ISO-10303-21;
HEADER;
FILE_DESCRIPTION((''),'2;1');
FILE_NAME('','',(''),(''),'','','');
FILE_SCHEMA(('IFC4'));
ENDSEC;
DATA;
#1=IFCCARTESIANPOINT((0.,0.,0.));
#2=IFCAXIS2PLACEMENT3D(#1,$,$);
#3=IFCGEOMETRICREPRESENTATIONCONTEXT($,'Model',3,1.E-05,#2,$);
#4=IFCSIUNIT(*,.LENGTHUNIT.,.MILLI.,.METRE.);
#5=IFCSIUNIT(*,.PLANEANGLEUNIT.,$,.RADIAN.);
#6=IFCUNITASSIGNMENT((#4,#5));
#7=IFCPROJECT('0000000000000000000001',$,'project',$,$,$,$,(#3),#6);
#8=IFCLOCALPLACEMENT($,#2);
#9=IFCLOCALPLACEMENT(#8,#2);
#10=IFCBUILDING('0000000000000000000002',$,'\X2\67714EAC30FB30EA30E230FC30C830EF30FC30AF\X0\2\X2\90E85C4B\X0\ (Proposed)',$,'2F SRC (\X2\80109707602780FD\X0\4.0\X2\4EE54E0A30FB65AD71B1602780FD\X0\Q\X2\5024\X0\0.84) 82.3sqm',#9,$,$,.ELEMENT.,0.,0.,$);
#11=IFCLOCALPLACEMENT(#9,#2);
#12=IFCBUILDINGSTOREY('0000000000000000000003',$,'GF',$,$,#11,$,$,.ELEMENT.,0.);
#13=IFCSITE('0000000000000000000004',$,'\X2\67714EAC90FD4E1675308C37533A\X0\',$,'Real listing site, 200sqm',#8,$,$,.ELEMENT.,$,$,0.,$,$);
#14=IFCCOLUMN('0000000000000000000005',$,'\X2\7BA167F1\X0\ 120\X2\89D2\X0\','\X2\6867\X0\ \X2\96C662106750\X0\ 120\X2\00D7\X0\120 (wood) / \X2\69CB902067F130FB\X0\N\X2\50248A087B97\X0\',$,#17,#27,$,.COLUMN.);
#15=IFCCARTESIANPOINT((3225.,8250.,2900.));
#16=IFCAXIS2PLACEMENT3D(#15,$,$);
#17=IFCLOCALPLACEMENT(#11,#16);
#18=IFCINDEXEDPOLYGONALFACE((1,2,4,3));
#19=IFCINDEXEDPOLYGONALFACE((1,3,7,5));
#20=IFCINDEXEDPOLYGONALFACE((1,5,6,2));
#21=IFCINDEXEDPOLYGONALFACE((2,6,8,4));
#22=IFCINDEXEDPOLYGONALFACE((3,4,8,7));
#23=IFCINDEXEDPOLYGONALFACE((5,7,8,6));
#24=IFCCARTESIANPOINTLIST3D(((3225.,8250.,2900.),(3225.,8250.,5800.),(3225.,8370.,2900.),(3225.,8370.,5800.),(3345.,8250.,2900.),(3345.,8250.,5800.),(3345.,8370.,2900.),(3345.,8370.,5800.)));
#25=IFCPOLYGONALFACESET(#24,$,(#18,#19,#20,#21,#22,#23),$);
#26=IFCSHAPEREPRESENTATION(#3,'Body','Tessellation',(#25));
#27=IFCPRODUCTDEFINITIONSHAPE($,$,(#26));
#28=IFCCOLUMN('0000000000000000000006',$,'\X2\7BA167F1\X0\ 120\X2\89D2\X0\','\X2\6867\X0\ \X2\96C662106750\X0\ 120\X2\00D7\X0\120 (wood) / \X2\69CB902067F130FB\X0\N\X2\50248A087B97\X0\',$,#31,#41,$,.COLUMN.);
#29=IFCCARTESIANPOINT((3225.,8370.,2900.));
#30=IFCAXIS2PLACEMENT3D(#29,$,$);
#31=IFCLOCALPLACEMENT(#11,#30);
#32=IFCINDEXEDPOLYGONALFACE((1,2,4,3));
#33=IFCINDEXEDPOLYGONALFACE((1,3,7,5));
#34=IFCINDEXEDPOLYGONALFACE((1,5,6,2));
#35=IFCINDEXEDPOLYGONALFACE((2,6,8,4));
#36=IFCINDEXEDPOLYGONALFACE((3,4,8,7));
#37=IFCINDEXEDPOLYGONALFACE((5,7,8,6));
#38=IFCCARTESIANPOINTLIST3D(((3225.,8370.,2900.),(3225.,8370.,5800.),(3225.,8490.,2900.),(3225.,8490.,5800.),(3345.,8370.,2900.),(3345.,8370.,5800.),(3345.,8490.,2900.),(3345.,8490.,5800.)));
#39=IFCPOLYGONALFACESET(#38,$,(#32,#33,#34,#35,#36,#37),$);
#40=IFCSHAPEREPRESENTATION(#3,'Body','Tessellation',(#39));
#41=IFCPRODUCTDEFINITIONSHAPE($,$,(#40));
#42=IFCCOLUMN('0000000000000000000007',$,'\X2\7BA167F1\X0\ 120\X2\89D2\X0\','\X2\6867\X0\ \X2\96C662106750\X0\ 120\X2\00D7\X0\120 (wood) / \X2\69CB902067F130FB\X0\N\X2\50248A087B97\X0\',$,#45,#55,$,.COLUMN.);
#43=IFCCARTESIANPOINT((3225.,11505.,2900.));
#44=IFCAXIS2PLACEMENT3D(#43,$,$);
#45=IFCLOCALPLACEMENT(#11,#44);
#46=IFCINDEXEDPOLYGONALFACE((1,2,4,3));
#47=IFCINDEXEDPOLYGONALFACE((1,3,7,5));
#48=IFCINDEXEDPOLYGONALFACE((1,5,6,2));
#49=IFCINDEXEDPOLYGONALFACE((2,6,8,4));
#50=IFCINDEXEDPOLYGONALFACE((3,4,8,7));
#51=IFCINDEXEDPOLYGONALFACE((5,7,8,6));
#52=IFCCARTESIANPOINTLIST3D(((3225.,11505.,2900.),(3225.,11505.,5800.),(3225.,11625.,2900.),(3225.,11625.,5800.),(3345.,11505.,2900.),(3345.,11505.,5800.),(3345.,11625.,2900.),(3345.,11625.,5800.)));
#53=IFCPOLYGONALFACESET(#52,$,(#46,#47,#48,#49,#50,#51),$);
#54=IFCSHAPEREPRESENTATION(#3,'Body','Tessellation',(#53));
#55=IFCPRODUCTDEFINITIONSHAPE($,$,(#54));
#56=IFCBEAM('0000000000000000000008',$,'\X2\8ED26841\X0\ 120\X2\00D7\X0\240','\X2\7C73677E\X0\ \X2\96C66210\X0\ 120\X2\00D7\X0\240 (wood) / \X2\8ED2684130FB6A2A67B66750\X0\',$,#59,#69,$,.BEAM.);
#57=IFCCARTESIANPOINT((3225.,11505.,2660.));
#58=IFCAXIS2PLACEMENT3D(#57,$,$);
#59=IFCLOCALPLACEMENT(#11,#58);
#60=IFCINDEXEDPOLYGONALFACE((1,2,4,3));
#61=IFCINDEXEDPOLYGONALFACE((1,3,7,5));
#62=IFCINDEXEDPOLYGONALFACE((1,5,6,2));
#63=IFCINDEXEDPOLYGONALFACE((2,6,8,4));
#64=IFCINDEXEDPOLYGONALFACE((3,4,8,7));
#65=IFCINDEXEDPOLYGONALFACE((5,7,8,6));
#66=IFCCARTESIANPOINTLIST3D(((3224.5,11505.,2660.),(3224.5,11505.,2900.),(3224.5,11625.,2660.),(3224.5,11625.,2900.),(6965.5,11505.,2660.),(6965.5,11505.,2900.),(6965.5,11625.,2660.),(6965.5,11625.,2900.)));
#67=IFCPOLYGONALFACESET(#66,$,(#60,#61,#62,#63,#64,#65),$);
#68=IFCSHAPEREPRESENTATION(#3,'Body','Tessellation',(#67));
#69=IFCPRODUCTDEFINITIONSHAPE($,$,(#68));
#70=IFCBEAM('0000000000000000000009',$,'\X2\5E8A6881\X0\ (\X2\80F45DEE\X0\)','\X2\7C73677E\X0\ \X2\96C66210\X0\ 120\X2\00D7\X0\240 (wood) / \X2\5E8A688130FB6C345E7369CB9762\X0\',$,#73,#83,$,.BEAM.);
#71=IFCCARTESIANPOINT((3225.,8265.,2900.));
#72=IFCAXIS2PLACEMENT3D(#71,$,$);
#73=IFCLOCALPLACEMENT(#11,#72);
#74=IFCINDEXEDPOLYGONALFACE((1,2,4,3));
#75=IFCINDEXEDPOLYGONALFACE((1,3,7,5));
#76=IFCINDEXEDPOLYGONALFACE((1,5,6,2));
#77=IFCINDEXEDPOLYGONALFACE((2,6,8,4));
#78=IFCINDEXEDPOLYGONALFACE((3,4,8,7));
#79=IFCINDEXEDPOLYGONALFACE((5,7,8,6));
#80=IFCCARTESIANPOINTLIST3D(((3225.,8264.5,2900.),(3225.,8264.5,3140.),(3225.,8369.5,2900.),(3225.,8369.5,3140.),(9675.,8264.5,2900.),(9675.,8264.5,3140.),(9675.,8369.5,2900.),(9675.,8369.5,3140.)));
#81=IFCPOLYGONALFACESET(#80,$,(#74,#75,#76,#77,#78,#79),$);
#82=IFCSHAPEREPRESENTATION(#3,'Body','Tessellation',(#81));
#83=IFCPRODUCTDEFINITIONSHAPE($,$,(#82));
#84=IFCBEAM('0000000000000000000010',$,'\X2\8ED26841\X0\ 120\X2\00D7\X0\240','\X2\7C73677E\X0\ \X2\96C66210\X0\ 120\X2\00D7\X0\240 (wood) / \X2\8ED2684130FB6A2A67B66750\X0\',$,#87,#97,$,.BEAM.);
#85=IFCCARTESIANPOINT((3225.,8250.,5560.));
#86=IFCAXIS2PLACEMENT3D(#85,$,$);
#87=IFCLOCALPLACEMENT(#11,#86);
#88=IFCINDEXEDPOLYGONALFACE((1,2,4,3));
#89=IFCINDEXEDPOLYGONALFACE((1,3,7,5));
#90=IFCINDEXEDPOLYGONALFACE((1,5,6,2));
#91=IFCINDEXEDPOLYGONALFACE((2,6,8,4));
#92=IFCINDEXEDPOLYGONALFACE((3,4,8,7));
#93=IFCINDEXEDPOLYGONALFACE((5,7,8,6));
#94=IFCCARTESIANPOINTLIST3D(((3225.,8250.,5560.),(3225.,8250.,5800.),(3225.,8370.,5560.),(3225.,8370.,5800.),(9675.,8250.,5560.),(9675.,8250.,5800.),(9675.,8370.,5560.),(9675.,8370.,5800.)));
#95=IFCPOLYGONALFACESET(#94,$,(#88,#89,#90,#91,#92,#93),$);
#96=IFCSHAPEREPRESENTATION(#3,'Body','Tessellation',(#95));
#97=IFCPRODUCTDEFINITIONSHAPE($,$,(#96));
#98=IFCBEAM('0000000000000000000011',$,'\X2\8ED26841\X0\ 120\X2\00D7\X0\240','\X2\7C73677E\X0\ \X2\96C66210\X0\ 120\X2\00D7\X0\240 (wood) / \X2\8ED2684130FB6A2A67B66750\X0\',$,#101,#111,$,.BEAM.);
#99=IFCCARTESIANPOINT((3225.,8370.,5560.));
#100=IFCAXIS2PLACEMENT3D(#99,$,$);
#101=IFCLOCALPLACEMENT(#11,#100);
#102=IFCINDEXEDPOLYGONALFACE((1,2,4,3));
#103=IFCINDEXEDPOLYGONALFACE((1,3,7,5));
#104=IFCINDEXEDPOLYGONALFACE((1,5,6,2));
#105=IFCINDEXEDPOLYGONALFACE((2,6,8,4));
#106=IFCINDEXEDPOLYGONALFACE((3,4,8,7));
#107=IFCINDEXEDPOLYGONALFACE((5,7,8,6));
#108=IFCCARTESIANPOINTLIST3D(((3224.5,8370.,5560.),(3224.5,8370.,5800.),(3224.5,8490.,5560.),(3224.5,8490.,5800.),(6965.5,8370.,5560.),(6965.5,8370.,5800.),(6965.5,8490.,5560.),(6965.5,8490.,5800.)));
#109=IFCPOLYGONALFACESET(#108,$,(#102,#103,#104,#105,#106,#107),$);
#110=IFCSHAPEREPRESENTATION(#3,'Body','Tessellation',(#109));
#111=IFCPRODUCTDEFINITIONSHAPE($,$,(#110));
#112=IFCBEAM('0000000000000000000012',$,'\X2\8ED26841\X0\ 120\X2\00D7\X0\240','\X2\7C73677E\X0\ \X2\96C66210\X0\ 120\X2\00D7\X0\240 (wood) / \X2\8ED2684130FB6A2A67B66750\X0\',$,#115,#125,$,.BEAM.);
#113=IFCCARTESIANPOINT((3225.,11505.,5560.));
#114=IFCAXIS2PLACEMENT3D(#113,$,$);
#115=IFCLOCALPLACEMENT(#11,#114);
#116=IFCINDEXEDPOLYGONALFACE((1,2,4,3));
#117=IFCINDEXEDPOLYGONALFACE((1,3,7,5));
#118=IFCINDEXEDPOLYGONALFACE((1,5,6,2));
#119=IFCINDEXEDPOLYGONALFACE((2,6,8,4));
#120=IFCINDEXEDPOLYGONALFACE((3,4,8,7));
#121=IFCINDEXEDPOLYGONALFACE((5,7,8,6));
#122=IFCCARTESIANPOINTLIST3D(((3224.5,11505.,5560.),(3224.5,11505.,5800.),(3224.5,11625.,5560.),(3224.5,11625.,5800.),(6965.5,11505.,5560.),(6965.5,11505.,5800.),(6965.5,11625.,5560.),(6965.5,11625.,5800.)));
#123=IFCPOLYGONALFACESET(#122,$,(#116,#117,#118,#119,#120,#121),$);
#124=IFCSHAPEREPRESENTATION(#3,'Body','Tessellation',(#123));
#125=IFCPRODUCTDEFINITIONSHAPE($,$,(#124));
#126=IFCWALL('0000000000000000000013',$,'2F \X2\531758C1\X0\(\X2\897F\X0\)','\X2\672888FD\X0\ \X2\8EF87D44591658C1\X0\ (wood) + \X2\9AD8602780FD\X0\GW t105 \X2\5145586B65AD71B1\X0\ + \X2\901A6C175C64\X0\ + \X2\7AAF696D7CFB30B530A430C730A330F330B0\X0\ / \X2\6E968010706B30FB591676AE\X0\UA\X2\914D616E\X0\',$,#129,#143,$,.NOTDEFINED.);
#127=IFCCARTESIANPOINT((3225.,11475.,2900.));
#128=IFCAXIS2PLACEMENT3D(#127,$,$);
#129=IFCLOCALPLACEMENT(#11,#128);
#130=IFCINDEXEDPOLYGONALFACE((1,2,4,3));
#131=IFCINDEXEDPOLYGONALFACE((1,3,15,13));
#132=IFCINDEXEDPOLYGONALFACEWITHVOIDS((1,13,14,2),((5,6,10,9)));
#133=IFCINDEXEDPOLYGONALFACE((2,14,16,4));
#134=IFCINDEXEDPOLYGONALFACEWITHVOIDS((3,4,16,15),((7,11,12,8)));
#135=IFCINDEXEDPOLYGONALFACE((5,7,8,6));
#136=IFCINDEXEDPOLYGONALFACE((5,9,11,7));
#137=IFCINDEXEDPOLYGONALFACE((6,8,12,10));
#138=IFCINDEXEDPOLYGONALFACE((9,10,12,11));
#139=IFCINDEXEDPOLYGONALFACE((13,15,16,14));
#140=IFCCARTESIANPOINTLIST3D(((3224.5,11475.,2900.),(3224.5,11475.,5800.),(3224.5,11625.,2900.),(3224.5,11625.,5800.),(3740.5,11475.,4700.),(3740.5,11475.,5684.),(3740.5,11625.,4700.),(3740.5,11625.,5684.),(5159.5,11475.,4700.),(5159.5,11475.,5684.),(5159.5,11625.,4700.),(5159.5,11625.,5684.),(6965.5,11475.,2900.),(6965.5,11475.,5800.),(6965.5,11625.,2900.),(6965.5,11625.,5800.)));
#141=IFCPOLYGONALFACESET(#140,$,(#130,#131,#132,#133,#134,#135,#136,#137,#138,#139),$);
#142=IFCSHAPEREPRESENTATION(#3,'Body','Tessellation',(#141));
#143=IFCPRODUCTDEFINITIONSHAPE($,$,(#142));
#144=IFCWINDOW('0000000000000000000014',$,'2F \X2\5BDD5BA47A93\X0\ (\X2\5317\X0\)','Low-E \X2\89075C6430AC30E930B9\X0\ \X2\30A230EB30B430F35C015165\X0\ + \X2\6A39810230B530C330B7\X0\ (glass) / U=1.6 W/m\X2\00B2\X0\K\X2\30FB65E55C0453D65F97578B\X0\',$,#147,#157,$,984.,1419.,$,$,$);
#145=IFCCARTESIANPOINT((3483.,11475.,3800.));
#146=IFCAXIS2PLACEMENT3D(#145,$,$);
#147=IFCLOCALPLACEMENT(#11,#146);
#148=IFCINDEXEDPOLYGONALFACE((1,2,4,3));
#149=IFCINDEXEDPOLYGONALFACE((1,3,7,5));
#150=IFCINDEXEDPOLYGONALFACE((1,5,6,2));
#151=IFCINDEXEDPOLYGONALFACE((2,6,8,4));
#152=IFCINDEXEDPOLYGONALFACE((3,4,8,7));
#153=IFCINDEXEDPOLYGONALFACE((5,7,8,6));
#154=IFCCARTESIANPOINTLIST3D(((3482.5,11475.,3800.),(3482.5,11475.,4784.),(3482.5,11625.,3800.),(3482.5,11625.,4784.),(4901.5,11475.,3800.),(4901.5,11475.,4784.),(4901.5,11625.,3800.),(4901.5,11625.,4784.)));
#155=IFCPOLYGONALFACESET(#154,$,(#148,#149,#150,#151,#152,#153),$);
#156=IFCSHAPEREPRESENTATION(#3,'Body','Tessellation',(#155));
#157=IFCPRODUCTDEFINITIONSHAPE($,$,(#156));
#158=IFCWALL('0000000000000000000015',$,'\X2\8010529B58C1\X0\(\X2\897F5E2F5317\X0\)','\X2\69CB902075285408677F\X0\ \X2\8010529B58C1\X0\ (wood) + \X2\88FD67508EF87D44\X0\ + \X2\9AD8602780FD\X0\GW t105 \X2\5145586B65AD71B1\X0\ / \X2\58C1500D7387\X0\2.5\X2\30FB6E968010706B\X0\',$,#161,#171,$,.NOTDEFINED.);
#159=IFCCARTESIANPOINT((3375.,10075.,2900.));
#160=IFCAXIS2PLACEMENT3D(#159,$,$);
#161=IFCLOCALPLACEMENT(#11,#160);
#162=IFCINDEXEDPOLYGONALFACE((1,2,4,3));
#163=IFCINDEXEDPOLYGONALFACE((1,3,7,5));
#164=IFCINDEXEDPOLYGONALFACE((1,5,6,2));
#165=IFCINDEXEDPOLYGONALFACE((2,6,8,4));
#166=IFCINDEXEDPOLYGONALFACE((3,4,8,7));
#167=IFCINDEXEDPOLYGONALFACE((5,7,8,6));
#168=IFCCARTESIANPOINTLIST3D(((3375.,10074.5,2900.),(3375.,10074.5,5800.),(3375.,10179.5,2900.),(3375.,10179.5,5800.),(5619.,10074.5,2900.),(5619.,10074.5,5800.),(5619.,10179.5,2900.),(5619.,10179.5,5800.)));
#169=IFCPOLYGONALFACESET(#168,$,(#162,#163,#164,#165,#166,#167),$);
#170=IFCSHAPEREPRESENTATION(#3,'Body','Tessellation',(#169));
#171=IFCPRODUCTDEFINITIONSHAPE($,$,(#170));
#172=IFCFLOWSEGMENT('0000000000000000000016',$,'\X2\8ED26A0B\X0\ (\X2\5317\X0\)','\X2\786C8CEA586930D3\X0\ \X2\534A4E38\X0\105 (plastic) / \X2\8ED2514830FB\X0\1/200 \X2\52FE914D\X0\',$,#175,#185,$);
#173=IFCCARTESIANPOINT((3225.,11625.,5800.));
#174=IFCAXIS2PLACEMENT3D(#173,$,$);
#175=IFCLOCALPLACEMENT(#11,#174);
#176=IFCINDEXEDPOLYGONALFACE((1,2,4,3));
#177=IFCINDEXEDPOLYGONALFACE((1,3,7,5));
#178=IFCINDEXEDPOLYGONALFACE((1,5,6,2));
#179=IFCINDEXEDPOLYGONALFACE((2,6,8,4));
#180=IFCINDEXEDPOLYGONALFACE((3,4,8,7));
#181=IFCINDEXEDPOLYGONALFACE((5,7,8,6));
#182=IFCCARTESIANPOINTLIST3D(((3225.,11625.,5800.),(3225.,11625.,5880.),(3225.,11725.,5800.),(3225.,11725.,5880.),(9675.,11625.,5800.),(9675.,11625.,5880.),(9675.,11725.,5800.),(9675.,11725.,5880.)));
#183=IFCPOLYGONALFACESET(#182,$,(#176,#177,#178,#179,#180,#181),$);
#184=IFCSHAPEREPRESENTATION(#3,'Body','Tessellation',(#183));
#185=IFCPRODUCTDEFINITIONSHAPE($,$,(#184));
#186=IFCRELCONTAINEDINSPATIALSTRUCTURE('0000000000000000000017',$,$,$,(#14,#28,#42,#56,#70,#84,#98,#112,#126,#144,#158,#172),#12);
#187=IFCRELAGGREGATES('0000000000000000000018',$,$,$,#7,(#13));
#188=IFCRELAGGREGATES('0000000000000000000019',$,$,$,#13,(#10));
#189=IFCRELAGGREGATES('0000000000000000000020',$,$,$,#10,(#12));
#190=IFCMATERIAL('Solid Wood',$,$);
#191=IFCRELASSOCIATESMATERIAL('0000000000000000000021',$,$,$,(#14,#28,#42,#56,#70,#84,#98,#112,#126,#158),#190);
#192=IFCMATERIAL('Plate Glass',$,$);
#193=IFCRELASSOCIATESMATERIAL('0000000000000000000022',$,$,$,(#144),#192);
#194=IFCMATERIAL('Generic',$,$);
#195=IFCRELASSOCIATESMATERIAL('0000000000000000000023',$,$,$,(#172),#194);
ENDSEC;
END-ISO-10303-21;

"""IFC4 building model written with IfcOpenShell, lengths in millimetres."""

from ifc_helpers import new_model, si_unit, frame, frame_2d, origin, place, context, project, spatial, rectangle, extrude, material, element, fill, save


model = new_model("IFC4")

# Units and contexts
model_context = context("Model", 3, precision=1e-05, world=origin())
ifc_project = project(units=[si_unit("LENGTHUNIT", "METRE", prefix="MILLI"), si_unit("PLANEANGLEUNIT", "RADIAN")], contexts=[model_context])

# Site, building, storey
site_placement = place(None, origin())
site = spatial("IfcSite", under=ifc_project, at=site_placement, Name="東京都世田谷区", ObjectType="Real listing site, 200sqm", CompositionType="ELEMENT", RefElevation=0.0)
building_placement = place(site_placement, origin())
building = spatial("IfcBuilding", under=site, at=building_placement, Name="東京・リモートワーク2部屋 (Proposed)", ObjectType="2F SRC (耐震性能4.0以上・断熱性能Q値0.84) 82.3sqm", CompositionType="ELEMENT", ElevationOfRefHeight=0.0, ElevationOfTerrain=0.0)
storey_placement = place(building_placement, origin())
storey = spatial("IfcBuildingStorey", under=building, at=storey_placement, Name="GF", CompositionType="ELEMENT", Elevation=0.0)

# Columns
ifc_material_1 = material(Name="Solid Wood")
column_1_placement = place(storey_placement, frame((3225.0, 8250.0, 2900.0)))
element("IfcColumn", 1, at=column_1_placement, inside=storey, material=ifc_material_1, Name="管柱 120角", Description="桧 集成材 120×120 (wood) / 構造柱・N値計算", PredefinedType="COLUMN", context=model_context, shape_type="SweptSolid", body=[
    extrude(rectangle(XDim=120.0, YDim=120.0, at=frame_2d((60.0, 60.0))), frame((3225.0, 8250.0, 2900.0)), (0.0, 0.0, 1.0), 2900.0),
])
column_2_placement = place(storey_placement, frame((3225.0, 8370.0, 2900.0)))
element("IfcColumn", 2, at=column_2_placement, inside=storey, material=ifc_material_1, Name="管柱 120角", Description="桧 集成材 120×120 (wood) / 構造柱・N値計算", PredefinedType="COLUMN", context=model_context, shape_type="SweptSolid", body=[
    extrude(rectangle(XDim=120.0, YDim=120.0, at=frame_2d((60.0, 60.0))), frame((3225.0, 8370.0, 2900.0)), (0.0, 0.0, 1.0), 2900.0),
])
column_3_placement = place(storey_placement, frame((3225.0, 11505.0, 2900.0)))
element("IfcColumn", 3, at=column_3_placement, inside=storey, material=ifc_material_1, Name="管柱 120角", Description="桧 集成材 120×120 (wood) / 構造柱・N値計算", PredefinedType="COLUMN", context=model_context, shape_type="SweptSolid", body=[
    extrude(rectangle(XDim=120.0, YDim=120.0, at=frame_2d((60.0, 60.0))), frame((3225.0, 11505.0, 2900.0)), (0.0, 0.0, 1.0), 2900.0),
])

# Beams
beam_1_placement = place(storey_placement, frame((3225.0, 11505.0, 2660.0)))
element("IfcBeam", 4, at=beam_1_placement, inside=storey, material=ifc_material_1, Name="軒桁 120×240", Description="米松 集成 120×240 (wood) / 軒桁・横架材", PredefinedType="BEAM", context=model_context, shape_type="SweptSolid", body=[
    extrude(rectangle(XDim=3741.0, YDim=120.0, at=frame_2d((1870.0, 60.0))), frame((3225.0, 11505.0, 2660.0)), (0.0, 0.0, 1.0), 240.0),
])
beam_2_placement = place(storey_placement, frame((3225.0, 8265.0, 2900.0)))
element("IfcBeam", 5, at=beam_2_placement, inside=storey, material=ifc_material_1, Name="床梁 (胴差)", Description="米松 集成 120×240 (wood) / 床梁・水平構面", PredefinedType="BEAM", context=model_context, shape_type="SweptSolid", body=[
    extrude(rectangle(XDim=6450.0, YDim=105.0, at=frame_2d((3225.0, 52.0))), frame((3225.0, 8265.0, 2900.0)), (0.0, 0.0, 1.0), 240.0),
])
beam_3_placement = place(storey_placement, frame((3225.0, 8250.0, 5560.0)))
element("IfcBeam", 6, at=beam_3_placement, inside=storey, material=ifc_material_1, Name="軒桁 120×240", Description="米松 集成 120×240 (wood) / 軒桁・横架材", PredefinedType="BEAM", context=model_context, shape_type="SweptSolid", body=[
    extrude(rectangle(XDim=6450.0, YDim=120.0, at=frame_2d((3225.0, 60.0))), frame((3225.0, 8250.0, 5560.0)), (0.0, 0.0, 1.0), 240.0),
])
beam_4_placement = place(storey_placement, frame((3225.0, 8370.0, 5560.0)))
element("IfcBeam", 7, at=beam_4_placement, inside=storey, material=ifc_material_1, Name="軒桁 120×240", Description="米松 集成 120×240 (wood) / 軒桁・横架材", PredefinedType="BEAM", context=model_context, shape_type="SweptSolid", body=[
    extrude(rectangle(XDim=3741.0, YDim=120.0, at=frame_2d((1870.0, 60.0))), frame((3225.0, 8370.0, 5560.0)), (0.0, 0.0, 1.0), 240.0),
])
beam_5_placement = place(storey_placement, frame((3225.0, 11505.0, 5560.0)))
element("IfcBeam", 8, at=beam_5_placement, inside=storey, material=ifc_material_1, Name="軒桁 120×240", Description="米松 集成 120×240 (wood) / 軒桁・横架材", PredefinedType="BEAM", context=model_context, shape_type="SweptSolid", body=[
    extrude(rectangle(XDim=3741.0, YDim=120.0, at=frame_2d((1870.0, 60.0))), frame((3225.0, 11505.0, 5560.0)), (0.0, 0.0, 1.0), 240.0),
])

# Wall, opening, window
wall_1_placement = place(storey_placement, frame((3225.0, 11475.0, 2900.0)))
wall_1 = element("IfcWall", 9, at=wall_1_placement, inside=storey, material=ifc_material_1, Name="2F 北壁(西)", Description="木製 軸組外壁 (wood) + 高性能GW t105 充填断熱 + 通気層 + 窯業系サイディング / 準耐火・外皮UA配慮", PredefinedType="NOTDEFINED", context=model_context, shape_type="SweptSolid", body=[
    extrude(rectangle(XDim=3741.0, YDim=150.0, at=frame_2d((1870.0, 75.0))), frame((3225.0, 11475.0, 2900.0)), (0.0, 0.0, 1.0), 2900.0),
])
opening_placement = place(storey_placement, frame((3483.0, 11475.0, 3800.0)))
opening = element("IfcOpeningElement", 10, at=opening_placement, cuts=wall_1, PredefinedType="NOTDEFINED", context=model_context, shape_type="SweptSolid", body=[
    extrude(rectangle(XDim=1419.0, YDim=150.0, at=frame_2d((709.0, 75.0))), frame((3483.0, 11475.0, 3800.0)), (0.0, 0.0, 1.0), 984.0),
])
ifc_material_2 = material(Name="Plate Glass")
window_placement = place(storey_placement, frame((3483.0, 11475.0, 3800.0)))
window = element("IfcWindow", 11, at=window_placement, inside=storey, material=ifc_material_2, Name="2F 寝室窓 (北)", Description="Low-E 複層ガラス アルゴン封入 + 樹脂サッシ (glass) / U=1.6 W/m²K・日射取得型", OverallHeight=984.0, OverallWidth=1419.0, context=model_context, shape_type="SweptSolid", body=[
    extrude(rectangle(XDim=1419.0, YDim=150.0, at=frame_2d((709.0, 75.0))), frame((3483.0, 11475.0, 3800.0)), (0.0, 0.0, 1.0), 984.0),
])
fill(opening, window)

# Wall
wall_2_placement = place(storey_placement, frame((3375.0, 10075.0, 2900.0)))
element("IfcWall", 12, at=wall_2_placement, inside=storey, material=ifc_material_1, Name="耐力壁(西帯北)", Description="構造用合板 耐力壁 (wood) + 製材軸組 + 高性能GW t105 充填断熱 / 壁倍率2.5・準耐火", PredefinedType="NOTDEFINED", context=model_context, shape_type="SweptSolid", body=[
    extrude(rectangle(XDim=2244.0, YDim=105.0, at=frame_2d((1122.0, 52.0))), frame((3375.0, 10075.0, 2900.0)), (0.0, 0.0, 1.0), 2900.0),
])

# Shared definitions
ifc_material_3 = material(Name="Generic")

# Flow segment
flow_segment_placement = place(storey_placement, frame((3225.0, 11625.0, 5800.0)))
element("IfcFlowSegment", 13, at=flow_segment_placement, inside=storey, material=ifc_material_3, Name="軒樋 (北)", Description="硬質塩ビ 半丸105 (plastic) / 軒先・1/200 勾配", context=model_context, shape_type="SweptSolid", body=[
    extrude(rectangle(XDim=6450.0, YDim=100.0, at=frame_2d((3225.0, 50.0))), frame((3225.0, 11625.0, 5800.0)), (0.0, 0.0, 1.0), 80.0),
])

save(model, "model.ifc")
